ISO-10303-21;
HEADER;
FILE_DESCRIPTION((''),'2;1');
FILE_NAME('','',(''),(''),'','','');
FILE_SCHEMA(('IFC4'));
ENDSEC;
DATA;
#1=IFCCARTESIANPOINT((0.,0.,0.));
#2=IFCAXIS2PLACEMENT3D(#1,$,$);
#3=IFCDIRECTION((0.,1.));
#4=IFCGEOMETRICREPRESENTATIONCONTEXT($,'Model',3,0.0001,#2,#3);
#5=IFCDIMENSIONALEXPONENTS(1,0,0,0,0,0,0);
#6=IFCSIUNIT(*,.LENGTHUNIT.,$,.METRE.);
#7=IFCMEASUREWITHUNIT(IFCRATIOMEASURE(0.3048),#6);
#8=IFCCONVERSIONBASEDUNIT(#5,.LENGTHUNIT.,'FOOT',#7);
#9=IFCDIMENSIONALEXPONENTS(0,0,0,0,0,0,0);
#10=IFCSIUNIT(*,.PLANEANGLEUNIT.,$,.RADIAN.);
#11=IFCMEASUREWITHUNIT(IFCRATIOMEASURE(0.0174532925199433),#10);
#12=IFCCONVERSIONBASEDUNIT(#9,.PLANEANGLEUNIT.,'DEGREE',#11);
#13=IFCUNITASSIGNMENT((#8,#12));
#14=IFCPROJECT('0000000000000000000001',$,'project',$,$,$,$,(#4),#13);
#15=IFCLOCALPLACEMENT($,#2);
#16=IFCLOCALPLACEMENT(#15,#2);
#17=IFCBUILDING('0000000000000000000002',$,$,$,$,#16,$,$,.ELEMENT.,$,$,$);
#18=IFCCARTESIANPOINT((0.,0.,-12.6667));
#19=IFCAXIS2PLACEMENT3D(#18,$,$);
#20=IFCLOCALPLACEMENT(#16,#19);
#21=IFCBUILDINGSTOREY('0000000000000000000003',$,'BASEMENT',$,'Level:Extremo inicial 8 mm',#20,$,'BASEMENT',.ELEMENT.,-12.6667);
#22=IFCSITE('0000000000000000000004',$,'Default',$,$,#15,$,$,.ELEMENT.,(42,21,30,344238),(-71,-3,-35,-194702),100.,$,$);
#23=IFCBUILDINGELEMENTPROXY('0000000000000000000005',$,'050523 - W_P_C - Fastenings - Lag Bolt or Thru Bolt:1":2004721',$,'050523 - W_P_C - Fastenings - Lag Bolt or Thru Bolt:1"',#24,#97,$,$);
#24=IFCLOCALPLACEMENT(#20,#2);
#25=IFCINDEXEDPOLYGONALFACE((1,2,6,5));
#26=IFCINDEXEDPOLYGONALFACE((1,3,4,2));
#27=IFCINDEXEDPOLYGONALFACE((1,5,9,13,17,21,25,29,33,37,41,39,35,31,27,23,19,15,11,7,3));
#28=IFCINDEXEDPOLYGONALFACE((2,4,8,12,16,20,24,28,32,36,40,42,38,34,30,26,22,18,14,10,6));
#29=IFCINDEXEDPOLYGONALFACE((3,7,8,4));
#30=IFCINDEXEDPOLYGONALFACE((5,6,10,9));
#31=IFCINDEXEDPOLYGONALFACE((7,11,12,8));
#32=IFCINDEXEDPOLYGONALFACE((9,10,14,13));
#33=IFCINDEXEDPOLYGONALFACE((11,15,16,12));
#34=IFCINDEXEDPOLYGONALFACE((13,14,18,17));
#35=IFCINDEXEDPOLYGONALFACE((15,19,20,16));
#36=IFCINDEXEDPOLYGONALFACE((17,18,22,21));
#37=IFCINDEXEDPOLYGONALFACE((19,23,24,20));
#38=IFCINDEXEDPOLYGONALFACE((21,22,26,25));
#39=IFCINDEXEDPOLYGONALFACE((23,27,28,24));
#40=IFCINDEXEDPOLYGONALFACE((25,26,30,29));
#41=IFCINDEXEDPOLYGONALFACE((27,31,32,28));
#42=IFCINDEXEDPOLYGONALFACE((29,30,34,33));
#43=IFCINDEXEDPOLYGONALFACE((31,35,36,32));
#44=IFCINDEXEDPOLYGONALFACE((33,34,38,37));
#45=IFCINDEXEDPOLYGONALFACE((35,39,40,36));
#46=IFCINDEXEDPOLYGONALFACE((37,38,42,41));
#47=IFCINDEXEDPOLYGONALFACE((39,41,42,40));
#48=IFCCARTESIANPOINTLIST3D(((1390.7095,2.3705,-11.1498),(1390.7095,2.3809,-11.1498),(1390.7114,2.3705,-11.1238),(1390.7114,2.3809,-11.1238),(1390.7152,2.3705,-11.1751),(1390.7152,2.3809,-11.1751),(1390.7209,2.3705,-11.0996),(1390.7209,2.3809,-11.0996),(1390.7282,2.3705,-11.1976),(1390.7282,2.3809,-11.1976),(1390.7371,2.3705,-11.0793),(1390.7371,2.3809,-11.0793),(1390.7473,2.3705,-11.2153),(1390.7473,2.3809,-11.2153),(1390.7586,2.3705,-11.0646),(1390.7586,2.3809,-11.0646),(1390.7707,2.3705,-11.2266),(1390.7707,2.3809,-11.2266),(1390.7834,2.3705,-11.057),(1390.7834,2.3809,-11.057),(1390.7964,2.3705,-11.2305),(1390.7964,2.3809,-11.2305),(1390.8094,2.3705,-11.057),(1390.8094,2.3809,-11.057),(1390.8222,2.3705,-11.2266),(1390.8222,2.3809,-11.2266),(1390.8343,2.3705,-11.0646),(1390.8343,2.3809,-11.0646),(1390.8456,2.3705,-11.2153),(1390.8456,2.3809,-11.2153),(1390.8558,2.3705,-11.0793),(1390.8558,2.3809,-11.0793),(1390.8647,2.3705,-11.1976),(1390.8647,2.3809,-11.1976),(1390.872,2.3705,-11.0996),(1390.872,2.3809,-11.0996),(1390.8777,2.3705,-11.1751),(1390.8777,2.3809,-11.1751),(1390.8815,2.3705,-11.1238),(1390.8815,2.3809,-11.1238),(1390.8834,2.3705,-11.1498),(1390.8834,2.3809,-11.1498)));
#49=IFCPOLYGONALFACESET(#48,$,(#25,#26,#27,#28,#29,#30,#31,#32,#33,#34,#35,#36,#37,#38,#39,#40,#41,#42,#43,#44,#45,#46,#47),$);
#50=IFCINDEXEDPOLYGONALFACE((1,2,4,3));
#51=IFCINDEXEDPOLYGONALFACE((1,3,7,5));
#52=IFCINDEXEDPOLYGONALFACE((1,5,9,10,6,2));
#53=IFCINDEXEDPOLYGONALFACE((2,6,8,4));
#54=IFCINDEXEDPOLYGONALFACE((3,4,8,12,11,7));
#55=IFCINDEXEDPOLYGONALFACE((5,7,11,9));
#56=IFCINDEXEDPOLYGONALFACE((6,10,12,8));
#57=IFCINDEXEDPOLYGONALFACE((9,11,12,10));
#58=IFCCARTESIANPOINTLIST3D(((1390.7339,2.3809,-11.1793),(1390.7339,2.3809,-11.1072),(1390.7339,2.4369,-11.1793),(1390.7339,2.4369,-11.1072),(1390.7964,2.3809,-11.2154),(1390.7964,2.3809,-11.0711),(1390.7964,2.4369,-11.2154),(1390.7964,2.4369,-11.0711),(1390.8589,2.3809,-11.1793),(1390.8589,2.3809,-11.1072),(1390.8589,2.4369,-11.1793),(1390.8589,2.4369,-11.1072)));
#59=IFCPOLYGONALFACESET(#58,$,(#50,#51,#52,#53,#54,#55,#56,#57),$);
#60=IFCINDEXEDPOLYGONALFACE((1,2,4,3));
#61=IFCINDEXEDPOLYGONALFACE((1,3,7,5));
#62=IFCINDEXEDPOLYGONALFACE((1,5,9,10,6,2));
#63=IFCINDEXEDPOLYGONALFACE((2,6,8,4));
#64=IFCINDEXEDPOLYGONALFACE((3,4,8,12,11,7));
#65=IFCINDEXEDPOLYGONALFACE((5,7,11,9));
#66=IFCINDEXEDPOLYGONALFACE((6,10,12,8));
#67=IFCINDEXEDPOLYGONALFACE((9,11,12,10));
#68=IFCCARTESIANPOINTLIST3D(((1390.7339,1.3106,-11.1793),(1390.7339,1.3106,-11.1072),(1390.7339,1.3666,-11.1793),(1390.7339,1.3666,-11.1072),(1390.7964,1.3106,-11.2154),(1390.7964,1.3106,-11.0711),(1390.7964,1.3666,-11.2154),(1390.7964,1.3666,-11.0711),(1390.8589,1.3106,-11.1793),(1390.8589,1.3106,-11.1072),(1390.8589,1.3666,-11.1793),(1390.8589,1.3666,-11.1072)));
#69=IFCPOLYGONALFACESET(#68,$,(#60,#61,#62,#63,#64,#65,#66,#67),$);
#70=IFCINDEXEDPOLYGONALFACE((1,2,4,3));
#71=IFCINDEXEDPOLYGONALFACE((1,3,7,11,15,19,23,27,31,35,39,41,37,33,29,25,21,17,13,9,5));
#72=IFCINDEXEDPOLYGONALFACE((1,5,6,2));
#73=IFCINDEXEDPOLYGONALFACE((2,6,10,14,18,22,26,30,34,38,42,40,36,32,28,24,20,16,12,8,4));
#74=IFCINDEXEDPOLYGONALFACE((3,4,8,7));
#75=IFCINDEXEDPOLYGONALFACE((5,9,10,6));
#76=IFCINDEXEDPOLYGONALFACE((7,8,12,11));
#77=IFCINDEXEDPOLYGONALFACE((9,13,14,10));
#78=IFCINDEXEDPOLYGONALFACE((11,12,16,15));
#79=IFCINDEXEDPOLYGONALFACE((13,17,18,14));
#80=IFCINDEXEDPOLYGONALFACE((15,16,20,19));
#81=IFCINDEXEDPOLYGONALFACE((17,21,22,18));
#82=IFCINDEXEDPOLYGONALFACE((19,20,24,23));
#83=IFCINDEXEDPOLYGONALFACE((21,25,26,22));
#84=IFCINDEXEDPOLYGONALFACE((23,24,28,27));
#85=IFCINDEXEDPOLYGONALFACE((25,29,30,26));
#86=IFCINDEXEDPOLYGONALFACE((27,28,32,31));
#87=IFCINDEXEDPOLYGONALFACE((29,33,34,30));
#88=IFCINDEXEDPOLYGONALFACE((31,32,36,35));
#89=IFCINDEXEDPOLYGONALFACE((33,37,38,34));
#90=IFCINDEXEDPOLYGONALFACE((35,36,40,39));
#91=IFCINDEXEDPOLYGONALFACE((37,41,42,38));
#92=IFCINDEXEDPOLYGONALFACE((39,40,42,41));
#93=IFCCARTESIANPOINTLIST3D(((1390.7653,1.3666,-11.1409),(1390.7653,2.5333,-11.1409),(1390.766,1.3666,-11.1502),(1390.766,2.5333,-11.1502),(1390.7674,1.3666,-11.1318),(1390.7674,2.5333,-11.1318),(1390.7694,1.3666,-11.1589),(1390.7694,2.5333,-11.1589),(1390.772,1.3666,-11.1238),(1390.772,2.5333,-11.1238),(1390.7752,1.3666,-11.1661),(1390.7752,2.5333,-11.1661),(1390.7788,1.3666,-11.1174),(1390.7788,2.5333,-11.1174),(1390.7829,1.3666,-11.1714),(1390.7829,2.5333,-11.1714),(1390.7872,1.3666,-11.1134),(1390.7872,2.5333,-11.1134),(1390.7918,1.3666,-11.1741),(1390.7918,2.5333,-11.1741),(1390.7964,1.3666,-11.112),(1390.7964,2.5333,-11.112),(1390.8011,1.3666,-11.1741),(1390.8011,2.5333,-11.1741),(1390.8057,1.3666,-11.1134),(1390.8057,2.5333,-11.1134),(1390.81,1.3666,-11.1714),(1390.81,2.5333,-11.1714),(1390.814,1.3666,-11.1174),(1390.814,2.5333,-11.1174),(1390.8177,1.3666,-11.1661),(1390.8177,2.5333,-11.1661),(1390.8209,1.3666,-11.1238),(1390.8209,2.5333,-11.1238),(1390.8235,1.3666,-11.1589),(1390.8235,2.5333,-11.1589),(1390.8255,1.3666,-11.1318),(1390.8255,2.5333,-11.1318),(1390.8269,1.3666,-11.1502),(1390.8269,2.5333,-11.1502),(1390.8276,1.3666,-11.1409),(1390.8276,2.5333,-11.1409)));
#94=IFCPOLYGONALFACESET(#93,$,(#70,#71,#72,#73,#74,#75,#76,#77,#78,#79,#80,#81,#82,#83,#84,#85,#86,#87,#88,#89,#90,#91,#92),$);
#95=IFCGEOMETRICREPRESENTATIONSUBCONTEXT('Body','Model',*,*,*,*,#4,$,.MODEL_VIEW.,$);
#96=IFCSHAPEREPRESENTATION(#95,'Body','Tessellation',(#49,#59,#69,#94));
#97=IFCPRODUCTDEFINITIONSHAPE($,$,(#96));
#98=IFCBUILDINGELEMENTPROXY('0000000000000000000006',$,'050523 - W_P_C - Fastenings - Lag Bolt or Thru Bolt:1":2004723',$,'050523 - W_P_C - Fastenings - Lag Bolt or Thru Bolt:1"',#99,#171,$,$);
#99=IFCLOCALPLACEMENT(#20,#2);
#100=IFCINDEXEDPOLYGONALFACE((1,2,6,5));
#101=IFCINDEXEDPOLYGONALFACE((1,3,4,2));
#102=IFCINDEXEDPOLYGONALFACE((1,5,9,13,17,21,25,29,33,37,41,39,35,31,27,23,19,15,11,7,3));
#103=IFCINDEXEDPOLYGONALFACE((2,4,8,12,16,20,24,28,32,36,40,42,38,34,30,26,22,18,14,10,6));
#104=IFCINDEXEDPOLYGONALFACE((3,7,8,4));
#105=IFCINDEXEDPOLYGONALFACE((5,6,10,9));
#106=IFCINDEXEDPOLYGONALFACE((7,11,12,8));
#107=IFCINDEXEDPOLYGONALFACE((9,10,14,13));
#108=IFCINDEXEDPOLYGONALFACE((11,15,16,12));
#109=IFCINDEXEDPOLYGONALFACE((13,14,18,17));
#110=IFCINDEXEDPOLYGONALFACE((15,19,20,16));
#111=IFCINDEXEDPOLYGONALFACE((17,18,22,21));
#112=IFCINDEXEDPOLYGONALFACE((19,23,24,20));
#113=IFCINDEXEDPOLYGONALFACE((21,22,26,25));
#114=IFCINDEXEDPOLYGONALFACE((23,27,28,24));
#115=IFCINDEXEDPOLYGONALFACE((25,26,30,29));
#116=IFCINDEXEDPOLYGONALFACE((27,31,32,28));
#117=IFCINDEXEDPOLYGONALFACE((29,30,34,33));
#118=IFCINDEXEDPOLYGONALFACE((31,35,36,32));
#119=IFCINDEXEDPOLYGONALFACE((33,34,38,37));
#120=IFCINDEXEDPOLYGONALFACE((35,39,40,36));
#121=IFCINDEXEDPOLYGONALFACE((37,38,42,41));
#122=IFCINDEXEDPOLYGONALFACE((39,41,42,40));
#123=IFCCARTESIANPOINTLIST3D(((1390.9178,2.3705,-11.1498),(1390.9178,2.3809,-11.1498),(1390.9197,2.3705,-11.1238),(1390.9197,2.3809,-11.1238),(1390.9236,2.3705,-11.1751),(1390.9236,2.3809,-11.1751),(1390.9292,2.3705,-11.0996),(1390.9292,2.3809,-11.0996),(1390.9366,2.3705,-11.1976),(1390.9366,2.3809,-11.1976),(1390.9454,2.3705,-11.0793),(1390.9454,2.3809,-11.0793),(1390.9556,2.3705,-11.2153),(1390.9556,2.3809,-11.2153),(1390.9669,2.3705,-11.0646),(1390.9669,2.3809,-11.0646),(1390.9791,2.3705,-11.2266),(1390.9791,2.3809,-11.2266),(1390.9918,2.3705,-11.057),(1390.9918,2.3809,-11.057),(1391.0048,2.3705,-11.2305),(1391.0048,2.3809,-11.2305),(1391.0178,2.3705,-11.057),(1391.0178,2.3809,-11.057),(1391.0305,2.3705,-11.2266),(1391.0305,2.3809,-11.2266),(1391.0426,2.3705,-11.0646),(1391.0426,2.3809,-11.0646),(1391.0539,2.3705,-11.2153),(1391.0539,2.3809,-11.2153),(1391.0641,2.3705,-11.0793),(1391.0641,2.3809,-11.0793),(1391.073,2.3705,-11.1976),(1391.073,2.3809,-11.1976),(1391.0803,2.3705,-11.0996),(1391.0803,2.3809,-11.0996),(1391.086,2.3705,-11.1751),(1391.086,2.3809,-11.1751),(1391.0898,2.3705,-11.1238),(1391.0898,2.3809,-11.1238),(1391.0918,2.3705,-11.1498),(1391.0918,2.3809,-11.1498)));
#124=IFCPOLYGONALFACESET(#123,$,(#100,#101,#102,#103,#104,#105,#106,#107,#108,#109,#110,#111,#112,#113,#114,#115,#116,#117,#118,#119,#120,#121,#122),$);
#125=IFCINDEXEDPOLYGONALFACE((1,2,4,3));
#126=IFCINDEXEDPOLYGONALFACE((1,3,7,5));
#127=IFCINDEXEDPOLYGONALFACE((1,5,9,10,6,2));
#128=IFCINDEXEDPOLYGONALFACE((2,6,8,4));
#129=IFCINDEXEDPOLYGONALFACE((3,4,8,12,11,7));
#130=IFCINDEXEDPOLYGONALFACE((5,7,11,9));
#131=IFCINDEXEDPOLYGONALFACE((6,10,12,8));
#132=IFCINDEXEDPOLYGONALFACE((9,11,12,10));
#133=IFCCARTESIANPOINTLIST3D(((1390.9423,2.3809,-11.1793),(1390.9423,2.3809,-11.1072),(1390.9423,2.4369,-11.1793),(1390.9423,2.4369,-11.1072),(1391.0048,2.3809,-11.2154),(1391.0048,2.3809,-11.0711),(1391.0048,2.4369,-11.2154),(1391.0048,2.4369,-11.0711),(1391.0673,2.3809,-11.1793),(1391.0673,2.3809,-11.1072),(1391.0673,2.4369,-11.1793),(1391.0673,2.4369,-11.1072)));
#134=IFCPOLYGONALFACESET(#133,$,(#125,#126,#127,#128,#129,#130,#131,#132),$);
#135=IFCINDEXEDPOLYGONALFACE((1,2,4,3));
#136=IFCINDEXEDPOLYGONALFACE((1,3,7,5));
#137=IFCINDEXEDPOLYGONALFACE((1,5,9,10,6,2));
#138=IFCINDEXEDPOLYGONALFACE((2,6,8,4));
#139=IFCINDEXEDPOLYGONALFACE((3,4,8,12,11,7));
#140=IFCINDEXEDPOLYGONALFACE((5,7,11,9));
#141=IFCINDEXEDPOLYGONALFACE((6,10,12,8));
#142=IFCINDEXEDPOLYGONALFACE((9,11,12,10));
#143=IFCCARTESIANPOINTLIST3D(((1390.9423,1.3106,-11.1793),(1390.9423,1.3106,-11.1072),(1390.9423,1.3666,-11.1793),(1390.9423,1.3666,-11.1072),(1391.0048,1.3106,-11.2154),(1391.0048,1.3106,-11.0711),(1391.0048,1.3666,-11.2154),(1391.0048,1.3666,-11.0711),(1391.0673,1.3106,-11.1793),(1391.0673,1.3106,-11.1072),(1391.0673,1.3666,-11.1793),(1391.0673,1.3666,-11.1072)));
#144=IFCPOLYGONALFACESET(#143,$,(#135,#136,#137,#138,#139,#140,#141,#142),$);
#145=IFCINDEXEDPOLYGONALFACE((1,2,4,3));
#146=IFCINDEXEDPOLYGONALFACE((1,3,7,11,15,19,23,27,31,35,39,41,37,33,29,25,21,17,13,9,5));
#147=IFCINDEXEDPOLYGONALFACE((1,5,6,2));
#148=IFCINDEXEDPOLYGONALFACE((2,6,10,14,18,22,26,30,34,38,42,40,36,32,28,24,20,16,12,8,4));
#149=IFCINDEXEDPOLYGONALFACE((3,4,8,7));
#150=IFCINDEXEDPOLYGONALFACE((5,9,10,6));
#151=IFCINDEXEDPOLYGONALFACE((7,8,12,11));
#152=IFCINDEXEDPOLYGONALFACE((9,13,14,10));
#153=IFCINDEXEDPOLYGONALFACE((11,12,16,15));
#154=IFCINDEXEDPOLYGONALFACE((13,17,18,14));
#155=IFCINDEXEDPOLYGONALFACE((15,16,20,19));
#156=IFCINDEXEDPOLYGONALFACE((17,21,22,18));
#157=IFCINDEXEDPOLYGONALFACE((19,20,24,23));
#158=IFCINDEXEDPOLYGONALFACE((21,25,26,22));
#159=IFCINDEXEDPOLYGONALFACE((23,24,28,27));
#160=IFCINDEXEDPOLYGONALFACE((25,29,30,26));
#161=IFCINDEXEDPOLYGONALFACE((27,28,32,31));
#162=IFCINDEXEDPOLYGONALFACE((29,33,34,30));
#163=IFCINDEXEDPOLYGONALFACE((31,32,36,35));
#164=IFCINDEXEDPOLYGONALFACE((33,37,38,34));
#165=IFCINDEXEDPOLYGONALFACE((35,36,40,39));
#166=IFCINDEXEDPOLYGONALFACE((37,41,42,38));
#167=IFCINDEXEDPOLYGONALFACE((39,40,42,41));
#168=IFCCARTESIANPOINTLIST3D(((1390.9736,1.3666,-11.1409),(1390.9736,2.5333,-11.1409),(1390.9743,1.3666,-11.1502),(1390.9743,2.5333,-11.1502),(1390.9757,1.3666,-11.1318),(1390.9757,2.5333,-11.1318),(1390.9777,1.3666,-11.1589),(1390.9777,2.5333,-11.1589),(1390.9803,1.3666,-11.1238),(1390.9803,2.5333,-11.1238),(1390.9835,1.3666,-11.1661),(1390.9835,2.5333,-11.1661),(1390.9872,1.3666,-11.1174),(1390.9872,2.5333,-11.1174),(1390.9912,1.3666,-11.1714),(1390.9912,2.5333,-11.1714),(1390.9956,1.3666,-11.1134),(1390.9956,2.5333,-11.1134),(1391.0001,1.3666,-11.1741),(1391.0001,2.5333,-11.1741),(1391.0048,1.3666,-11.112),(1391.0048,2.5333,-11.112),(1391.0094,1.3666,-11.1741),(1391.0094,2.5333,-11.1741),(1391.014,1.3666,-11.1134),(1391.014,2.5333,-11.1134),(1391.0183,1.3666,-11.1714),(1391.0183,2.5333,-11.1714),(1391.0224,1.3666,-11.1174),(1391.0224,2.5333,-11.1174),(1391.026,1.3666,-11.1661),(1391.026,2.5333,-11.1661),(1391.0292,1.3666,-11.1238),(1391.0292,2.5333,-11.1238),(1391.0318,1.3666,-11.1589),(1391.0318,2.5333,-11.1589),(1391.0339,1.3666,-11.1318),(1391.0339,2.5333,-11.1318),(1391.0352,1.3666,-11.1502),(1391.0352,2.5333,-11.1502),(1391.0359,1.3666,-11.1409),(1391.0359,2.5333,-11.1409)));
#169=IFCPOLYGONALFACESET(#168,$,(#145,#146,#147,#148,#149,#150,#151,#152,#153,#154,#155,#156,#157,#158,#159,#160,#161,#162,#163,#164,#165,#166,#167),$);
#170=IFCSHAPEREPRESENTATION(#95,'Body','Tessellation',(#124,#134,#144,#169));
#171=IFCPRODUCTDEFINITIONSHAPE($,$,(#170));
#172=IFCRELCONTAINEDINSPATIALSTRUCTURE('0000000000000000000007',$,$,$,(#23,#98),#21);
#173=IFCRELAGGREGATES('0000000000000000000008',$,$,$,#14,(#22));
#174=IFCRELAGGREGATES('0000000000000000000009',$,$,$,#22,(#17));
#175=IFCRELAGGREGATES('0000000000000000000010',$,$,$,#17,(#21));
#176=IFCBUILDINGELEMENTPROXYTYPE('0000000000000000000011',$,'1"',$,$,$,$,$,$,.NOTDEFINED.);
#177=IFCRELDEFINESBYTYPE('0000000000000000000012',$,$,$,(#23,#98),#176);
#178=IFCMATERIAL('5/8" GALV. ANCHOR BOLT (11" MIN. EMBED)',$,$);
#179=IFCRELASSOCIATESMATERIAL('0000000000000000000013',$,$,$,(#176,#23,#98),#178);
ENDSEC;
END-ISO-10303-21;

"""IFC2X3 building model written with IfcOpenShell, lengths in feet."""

from ifc_helpers import new_model, entity, si_unit, converted_unit, direction, frame, frame_2d, origin, place, context, subcontext, project, spatial, polyline, circle, outline, extrude, source, transform, mapped, material, type_object, type_shapes, element, save


model = new_model("IFC2X3")

# Units and contexts
model_context = context("Model", 3, precision=0.0001, world=origin(), true_north=direction((0.0, 1.0)))
body_context = subcontext(model_context, "Body", "Model", "MODEL_VIEW")
ifc_project = project(units=[converted_unit("LENGTHUNIT", "FOOT", entity("IfcRatioMeasure", 0.3048), si_unit("LENGTHUNIT", "METRE"), dimensions=[1, 0, 0, 0, 0, 0, 0]), converted_unit("PLANEANGLEUNIT", "DEGREE", entity("IfcRatioMeasure", 0.0174532925199433), si_unit("PLANEANGLEUNIT", "RADIAN"), dimensions=[0, 0, 0, 0, 0, 0, 0])], contexts=[model_context])

# Site, building, storey
site_placement = place(None, origin())
site = spatial("IfcSite", under=ifc_project, at=site_placement, Name="Default", CompositionType="ELEMENT", RefLatitude=(42, 21, 30, 344238), RefLongitude=(-71, -3, -35, -194702), RefElevation=100.0)
building_placement = place(site_placement, origin())
building = spatial("IfcBuilding", under=site, at=building_placement, CompositionType="ELEMENT")
storey_placement = place(building_placement, frame((0.0, 0.0, -12.6667)))
storey = spatial("IfcBuildingStorey", under=building, at=storey_placement, Name="BASEMENT", ObjectType="Level:Extremo inicial 8 mm", LongName="BASEMENT", CompositionType="ELEMENT", Elevation=-12.6667)

# Building element proxies
ifc_material_1 = material(Name="5/8\" GALV. ANCHOR BOLT (11\" MIN. EMBED)")
building_element_proxy_type_1 = type_object("IfcBuildingElementProxyType", Name="1\"", PredefinedType="NOTDEFINED", material=ifc_material_1)
shared_shape_1 = source(origin(), body_context, "Body", "SweptSolid", [
    extrude(circle(Radius=0.0872, at=frame_2d((0.0, 0.0), x_axis=(1.0, 0.0))), frame((0.0, 0.0, -1.0143), z_axis=(0.0, 0.0, 1.0), x_axis=(0.0, -1.0, 0.0)), (0.0, 0.0, 1.0), 0.0104),
    extrude(outline(polyline([(-0.0361, -0.0625), (0.0361, -0.0625), (0.0722, 0.0), (0.0361, 0.0625), (-0.0361, 0.0625), (-0.0722, 0.0), (-0.0361, -0.0625)])), frame((0.0, 0.0, -1.0703), z_axis=(0.0, 0.0, 1.0), x_axis=(0.866025, -0.5, 0.0)), (0.0, 0.0, 1.0), 0.056),
    extrude(outline(polyline([(-0.0361, -0.0625), (0.0361, -0.0625), (0.0722, 0.0), (0.0361, 0.0625), (-0.0361, 0.0625), (-0.0722, 0.0), (-0.0361, -0.0625)])), frame((0.0, 0.0, 0.0), z_axis=(0.0, 0.0, 1.0), x_axis=(0.0, -1.0, 0.0)), (0.0, 0.0, 1.0), 0.056),
    extrude(circle(Radius=0.0312, at=frame_2d((0.0, 0.0), x_axis=(1.0, 0.0))), frame((0.0, 0.0, -1.1667), z_axis=(0.0, 0.0, 1.0), x_axis=(0.0, 1.0, 0.0)), (0.0, 0.0, 1.0), 1.1667),
])
type_shapes(building_element_proxy_type_1, [shared_shape_1])
for number, where, z_axis, x_axis, name in (
    (1, (1390.7964, 1.3666, -11.1432), (0.0, -1.0, 0.0), (1.0, 0.0, 0.0), "050523 - W_P_C - Fastenings - Lag Bolt or Thru Bolt:1\":2004721"),
    (2, (1391.0048, 1.3666, -11.1432), (0.0, -1.0, 0.0), (1.0, 0.0, 0.0), "050523 - W_P_C - Fastenings - Lag Bolt or Thru Bolt:1\":2004723"),
):
    element("IfcBuildingElementProxy", number, at=place(storey_placement, frame(where, z_axis=z_axis, x_axis=x_axis)), inside=storey, type_object=building_element_proxy_type_1, material=ifc_material_1, Name=name, ObjectType="050523 - W_P_C - Fastenings - Lag Bolt or Thru Bolt:1\"", context=body_context, shape_type="MappedRepresentation", body=[
        mapped(shared_shape_1, transform((0.0, 0.0, 0.0), scale=1.0)),
    ])

save(model, "model.ifc")
